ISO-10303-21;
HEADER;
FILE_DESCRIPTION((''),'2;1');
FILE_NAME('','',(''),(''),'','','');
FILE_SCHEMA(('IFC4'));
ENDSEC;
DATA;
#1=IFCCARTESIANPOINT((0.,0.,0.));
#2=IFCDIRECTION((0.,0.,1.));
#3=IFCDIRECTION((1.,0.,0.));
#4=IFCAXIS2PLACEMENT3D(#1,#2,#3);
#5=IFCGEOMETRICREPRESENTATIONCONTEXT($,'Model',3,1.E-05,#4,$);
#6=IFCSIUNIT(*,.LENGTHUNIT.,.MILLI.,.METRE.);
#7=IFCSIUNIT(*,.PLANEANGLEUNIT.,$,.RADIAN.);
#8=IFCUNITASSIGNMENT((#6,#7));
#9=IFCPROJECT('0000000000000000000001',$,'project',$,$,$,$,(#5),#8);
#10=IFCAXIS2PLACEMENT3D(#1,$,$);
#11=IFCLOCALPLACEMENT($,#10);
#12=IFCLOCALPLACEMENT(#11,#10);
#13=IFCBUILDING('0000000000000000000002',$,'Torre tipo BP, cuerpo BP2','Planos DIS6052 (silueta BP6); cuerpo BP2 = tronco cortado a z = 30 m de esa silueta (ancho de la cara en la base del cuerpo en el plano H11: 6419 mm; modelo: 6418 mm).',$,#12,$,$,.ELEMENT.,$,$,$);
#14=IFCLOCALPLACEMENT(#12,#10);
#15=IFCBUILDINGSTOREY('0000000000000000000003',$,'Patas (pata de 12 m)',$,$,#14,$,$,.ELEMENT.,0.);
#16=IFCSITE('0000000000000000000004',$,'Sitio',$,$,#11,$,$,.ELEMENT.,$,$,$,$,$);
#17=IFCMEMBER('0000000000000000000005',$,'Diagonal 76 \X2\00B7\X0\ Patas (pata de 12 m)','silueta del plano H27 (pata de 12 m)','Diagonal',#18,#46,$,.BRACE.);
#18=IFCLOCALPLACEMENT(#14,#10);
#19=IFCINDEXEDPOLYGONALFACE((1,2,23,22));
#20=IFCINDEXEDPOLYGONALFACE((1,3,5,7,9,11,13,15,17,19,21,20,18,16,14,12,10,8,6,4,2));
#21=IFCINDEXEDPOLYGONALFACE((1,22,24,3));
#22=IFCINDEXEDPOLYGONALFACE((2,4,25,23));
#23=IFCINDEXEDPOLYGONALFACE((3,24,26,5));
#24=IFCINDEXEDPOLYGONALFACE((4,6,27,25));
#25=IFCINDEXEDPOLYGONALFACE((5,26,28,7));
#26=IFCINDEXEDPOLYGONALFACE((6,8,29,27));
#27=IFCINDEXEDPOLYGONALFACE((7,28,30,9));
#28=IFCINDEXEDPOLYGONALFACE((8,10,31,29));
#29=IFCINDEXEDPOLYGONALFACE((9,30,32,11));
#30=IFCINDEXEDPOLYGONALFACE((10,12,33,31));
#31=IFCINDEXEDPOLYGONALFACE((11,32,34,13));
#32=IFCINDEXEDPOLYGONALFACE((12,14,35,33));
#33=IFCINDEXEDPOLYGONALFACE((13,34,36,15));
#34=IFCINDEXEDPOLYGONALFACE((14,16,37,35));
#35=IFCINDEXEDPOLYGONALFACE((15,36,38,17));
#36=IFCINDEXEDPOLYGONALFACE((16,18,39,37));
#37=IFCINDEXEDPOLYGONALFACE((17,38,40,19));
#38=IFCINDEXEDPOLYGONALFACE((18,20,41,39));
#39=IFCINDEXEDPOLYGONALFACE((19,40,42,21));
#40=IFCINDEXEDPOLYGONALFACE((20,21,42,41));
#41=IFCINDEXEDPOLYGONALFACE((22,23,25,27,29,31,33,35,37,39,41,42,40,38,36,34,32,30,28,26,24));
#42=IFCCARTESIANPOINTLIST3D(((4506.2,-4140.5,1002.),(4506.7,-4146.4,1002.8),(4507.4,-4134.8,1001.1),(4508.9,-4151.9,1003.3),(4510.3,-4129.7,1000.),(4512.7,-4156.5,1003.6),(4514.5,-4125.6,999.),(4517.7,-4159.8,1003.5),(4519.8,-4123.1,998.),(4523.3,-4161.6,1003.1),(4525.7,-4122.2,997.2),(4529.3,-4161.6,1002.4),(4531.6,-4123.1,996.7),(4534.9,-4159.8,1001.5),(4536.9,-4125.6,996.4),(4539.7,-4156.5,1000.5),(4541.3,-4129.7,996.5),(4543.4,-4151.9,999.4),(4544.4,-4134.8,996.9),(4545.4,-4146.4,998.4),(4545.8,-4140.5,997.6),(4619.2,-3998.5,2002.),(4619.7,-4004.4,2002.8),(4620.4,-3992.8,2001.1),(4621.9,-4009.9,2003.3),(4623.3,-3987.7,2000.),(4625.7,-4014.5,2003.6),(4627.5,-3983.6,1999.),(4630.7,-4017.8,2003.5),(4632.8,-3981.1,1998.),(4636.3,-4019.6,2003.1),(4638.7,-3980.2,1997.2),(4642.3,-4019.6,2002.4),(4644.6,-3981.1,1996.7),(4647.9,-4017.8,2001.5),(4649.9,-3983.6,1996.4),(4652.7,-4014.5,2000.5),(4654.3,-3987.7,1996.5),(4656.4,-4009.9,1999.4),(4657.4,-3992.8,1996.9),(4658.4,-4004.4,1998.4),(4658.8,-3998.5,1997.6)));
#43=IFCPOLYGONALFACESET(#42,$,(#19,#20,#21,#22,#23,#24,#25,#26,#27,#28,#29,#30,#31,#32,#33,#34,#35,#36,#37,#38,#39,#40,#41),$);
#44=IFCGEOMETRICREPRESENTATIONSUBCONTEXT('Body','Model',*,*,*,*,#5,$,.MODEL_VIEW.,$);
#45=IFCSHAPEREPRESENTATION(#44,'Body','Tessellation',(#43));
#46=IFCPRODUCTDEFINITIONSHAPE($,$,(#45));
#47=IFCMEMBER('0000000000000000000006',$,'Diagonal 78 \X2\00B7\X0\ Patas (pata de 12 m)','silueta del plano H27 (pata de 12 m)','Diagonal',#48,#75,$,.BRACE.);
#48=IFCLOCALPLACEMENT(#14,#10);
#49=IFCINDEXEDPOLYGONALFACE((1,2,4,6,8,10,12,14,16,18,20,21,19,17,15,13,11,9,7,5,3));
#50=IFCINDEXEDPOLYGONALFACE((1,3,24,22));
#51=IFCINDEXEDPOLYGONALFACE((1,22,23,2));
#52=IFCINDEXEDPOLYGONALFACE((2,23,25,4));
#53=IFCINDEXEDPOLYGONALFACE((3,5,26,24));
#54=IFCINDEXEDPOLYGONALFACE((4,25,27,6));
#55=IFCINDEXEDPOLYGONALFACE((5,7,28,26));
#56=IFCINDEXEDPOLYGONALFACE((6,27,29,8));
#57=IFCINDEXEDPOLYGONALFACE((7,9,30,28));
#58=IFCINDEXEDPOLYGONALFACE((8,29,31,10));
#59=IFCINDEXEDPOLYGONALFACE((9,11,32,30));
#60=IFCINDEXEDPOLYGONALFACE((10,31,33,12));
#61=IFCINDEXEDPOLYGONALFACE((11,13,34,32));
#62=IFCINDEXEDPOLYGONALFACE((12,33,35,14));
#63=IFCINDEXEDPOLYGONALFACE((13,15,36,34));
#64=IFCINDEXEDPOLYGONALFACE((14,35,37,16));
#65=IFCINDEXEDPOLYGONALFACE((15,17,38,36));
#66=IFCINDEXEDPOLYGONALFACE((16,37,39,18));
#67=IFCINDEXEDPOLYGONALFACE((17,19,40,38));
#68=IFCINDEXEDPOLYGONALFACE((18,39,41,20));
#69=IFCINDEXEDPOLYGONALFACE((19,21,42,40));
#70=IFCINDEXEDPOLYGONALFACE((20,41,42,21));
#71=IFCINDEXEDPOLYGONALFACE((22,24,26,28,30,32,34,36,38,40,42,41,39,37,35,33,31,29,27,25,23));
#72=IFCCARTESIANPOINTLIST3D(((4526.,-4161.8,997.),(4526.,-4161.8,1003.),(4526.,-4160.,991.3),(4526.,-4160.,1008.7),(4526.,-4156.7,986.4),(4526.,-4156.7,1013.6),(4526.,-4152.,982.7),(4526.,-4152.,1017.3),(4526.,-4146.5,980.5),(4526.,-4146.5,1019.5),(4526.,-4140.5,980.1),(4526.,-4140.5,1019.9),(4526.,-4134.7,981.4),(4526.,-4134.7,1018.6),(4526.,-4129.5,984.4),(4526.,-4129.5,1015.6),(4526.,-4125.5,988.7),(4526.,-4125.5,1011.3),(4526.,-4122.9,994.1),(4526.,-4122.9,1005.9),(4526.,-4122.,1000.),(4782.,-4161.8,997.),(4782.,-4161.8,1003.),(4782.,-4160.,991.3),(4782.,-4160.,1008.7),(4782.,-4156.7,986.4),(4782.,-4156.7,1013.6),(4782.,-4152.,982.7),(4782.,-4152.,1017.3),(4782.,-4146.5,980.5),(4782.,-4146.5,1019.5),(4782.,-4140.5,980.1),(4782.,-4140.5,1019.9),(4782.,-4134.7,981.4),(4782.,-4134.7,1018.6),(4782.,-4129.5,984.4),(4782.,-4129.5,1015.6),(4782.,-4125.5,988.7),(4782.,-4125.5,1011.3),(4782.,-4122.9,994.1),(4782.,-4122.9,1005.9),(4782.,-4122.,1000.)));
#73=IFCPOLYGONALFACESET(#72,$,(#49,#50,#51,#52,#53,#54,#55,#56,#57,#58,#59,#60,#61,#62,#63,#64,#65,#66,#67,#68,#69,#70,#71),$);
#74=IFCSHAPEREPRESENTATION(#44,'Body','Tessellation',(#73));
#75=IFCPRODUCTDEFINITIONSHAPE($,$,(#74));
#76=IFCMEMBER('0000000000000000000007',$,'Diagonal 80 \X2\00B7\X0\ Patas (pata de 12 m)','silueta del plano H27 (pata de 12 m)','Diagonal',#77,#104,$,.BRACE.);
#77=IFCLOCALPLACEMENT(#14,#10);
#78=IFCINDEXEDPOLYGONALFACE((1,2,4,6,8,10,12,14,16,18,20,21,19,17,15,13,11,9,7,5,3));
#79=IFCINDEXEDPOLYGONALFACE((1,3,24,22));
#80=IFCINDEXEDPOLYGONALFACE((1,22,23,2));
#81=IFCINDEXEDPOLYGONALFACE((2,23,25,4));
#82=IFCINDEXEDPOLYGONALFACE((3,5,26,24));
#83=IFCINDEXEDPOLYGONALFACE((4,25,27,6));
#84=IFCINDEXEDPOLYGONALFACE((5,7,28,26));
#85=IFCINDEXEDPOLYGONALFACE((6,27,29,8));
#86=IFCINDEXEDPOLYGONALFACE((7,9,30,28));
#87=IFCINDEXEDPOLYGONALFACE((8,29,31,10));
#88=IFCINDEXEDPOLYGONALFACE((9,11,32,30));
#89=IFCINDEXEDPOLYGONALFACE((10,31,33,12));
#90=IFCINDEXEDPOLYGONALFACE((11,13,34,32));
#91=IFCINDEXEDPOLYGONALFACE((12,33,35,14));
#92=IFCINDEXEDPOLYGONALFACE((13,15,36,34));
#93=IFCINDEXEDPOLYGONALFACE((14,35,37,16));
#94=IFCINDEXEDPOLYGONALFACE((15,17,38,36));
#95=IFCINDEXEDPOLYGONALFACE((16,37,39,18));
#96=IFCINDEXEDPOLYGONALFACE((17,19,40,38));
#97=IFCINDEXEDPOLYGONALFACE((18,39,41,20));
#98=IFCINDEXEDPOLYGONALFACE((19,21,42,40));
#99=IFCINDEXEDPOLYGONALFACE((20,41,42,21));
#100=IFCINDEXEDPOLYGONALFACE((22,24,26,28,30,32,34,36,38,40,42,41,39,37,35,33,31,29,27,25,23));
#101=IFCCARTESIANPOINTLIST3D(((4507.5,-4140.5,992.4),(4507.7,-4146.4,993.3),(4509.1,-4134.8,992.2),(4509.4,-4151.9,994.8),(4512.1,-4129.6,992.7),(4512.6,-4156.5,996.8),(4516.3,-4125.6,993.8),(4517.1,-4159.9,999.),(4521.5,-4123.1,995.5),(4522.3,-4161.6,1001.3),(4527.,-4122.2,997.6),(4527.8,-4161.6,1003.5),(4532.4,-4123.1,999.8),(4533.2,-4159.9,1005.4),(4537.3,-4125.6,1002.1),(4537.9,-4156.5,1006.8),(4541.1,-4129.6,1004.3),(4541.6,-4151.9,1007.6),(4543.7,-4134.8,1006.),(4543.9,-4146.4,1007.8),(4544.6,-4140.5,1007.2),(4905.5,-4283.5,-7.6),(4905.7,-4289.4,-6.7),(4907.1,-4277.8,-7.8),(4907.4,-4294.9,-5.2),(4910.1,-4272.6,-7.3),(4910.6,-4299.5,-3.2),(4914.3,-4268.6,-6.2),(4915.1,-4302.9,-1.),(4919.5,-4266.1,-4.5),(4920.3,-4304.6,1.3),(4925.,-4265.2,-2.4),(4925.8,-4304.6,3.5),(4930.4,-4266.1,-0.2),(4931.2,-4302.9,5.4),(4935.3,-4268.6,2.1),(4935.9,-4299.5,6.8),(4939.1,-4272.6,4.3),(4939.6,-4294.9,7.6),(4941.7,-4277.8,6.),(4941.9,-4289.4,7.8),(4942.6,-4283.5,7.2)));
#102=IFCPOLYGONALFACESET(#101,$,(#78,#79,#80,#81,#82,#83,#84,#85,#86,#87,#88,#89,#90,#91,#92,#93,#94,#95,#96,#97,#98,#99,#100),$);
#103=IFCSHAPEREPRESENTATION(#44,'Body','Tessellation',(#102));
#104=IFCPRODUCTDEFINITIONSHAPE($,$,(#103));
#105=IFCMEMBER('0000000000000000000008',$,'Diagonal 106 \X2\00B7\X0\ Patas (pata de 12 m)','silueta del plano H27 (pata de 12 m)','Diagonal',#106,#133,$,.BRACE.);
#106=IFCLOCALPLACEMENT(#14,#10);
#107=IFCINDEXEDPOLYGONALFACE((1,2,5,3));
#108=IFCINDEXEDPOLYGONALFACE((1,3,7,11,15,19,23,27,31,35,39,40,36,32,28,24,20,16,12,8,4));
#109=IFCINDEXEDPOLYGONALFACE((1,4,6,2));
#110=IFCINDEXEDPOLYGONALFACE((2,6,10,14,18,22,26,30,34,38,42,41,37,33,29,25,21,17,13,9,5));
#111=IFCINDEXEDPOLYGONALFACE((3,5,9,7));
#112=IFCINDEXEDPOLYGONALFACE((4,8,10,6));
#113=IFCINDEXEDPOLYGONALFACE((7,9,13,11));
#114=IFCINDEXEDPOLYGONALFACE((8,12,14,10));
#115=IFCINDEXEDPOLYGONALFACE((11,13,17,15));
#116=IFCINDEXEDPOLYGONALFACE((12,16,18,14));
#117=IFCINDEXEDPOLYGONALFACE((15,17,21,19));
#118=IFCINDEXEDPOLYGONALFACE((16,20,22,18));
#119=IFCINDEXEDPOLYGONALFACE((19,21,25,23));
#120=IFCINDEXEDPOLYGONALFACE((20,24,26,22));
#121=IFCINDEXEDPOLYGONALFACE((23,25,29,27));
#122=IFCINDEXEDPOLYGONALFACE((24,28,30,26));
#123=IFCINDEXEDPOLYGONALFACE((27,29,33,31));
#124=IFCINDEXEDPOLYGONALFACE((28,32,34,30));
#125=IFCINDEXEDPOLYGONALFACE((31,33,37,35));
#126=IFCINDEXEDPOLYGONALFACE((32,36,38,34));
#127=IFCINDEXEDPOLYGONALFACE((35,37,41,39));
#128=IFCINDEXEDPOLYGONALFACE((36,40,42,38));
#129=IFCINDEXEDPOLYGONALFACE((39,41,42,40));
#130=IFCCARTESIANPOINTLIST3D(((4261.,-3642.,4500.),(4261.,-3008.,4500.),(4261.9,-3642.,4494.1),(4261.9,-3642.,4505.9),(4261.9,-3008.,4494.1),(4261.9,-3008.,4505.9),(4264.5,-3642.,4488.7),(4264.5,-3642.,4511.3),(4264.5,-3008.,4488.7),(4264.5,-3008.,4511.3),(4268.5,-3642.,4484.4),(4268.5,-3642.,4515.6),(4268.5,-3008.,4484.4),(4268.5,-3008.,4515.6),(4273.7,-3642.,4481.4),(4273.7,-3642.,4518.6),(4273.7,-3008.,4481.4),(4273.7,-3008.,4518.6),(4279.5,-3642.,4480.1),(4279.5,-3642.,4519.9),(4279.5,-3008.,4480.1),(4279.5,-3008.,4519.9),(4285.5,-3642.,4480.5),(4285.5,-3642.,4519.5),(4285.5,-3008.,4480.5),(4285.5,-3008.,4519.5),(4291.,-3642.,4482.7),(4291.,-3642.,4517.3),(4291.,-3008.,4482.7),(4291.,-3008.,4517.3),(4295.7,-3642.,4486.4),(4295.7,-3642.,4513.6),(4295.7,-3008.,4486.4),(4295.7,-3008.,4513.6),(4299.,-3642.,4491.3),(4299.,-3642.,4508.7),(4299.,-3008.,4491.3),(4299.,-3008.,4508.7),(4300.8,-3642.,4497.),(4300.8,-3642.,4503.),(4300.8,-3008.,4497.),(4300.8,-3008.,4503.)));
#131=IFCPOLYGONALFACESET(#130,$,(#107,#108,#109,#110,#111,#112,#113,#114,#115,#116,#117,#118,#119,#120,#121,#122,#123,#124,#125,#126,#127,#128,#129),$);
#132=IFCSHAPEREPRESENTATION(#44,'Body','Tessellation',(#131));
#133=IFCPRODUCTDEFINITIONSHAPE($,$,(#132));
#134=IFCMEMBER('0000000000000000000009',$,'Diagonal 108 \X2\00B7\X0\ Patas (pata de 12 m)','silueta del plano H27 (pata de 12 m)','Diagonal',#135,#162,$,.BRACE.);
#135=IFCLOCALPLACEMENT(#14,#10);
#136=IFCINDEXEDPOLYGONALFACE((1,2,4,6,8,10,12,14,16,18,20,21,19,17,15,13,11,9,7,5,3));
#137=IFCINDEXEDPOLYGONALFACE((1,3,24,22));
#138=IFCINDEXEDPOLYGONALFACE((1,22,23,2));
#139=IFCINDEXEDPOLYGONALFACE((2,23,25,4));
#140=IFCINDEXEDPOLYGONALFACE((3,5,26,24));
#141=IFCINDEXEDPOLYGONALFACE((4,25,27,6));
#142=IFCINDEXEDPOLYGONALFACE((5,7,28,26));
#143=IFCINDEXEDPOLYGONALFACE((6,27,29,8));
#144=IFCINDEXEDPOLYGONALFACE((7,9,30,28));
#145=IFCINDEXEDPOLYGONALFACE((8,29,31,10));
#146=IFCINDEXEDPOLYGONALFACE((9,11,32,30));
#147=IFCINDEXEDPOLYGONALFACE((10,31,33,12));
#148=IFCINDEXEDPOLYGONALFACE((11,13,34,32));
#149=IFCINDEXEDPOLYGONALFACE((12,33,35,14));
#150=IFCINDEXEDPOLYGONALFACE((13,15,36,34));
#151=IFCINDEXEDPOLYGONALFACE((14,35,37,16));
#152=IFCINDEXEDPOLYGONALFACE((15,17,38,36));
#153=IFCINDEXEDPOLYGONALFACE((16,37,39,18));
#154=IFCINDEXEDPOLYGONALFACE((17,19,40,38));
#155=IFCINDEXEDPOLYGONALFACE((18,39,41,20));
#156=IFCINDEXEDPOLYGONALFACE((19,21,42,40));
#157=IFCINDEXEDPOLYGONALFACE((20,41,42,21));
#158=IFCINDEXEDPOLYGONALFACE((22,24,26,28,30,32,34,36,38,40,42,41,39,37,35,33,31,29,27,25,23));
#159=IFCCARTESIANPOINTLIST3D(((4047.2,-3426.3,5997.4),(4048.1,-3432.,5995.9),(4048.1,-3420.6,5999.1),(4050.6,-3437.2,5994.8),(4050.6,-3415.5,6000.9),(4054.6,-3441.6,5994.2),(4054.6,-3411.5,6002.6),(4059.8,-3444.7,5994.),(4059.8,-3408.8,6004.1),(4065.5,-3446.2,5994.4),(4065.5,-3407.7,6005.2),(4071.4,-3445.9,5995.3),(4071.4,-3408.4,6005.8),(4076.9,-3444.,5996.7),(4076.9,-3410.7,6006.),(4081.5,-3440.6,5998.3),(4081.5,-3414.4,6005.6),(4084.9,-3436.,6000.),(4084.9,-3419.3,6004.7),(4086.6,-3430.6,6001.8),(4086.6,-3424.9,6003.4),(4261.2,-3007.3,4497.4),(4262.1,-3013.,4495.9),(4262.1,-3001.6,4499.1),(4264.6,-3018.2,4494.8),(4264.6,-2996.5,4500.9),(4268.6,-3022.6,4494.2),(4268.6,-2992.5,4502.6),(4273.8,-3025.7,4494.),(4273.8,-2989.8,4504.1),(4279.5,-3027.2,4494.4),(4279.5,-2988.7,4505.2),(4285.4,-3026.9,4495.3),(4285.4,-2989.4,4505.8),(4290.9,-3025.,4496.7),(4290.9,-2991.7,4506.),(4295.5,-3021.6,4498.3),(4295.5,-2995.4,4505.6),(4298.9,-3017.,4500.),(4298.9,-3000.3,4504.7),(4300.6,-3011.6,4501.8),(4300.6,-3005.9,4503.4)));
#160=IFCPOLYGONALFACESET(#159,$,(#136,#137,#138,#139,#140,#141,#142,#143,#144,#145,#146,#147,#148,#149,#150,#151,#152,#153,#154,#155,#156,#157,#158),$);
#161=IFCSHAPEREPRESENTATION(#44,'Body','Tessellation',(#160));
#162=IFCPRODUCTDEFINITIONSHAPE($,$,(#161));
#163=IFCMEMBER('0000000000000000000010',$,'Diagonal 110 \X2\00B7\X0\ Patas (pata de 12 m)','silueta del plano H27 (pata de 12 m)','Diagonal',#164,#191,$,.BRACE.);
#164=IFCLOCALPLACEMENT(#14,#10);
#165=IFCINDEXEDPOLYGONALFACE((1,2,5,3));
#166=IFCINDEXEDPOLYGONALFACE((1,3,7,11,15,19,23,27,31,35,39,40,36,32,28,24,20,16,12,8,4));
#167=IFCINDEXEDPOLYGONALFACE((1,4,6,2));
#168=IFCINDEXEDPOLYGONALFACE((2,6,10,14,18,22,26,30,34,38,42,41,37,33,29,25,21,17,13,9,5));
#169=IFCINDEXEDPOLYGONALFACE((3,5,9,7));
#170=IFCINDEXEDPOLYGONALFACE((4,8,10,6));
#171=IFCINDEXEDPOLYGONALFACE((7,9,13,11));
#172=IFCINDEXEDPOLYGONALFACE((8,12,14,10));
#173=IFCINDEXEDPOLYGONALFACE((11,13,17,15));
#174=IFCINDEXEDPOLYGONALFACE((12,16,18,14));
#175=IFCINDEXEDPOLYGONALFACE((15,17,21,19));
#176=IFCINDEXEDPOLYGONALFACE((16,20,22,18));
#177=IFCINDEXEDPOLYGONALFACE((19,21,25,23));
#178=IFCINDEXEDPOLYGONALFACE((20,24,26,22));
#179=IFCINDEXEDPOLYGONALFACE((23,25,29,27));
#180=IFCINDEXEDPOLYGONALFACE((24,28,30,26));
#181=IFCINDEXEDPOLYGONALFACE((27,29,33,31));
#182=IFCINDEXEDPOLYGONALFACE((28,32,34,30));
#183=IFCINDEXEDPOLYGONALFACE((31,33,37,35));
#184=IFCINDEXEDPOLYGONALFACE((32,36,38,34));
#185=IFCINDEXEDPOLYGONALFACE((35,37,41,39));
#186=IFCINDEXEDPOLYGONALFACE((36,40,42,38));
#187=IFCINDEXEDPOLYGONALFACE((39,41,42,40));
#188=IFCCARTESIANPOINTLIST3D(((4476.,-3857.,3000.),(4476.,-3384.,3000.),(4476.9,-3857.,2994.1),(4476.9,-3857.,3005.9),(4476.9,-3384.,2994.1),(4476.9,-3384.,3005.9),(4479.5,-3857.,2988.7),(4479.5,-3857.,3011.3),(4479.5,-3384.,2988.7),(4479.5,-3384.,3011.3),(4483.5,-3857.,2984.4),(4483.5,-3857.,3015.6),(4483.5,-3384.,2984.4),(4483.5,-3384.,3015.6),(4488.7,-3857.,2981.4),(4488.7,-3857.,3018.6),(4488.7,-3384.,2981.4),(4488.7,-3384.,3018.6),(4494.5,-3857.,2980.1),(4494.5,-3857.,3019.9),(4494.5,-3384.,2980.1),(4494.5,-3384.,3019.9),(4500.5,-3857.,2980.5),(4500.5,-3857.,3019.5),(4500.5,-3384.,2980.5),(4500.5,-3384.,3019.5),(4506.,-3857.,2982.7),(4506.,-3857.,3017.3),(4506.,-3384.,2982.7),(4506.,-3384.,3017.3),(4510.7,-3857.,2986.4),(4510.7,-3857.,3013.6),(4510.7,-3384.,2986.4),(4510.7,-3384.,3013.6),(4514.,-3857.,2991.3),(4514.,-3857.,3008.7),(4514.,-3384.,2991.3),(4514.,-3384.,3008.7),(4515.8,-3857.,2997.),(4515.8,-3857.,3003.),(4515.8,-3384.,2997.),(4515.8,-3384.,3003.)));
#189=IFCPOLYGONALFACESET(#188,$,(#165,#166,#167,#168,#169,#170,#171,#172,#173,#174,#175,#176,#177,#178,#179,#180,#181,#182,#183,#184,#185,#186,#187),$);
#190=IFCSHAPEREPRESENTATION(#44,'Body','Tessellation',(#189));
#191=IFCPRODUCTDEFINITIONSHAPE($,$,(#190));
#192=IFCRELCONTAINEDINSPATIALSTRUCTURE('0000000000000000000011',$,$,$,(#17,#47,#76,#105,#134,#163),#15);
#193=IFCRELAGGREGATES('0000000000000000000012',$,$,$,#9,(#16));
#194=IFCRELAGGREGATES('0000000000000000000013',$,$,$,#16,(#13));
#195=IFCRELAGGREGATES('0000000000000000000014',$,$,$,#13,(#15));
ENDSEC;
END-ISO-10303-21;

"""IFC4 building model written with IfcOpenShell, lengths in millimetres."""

from ifc_helpers import new_model, si_unit, frame, origin, origin_with_axes, place, context, subcontext, project, spatial, circle, extrude, element, save


model = new_model("IFC4")

# Units and contexts
model_context = context("Model", 3, precision=1e-05, world=origin_with_axes())
body_context = subcontext(model_context, "Body", "Model", "MODEL_VIEW")
ifc_project = project(units=[si_unit("LENGTHUNIT", "METRE", prefix="MILLI"), si_unit("PLANEANGLEUNIT", "RADIAN")], contexts=[model_context])

# Site, building, storey
site_placement = place(None, origin())
site = spatial("IfcSite", under=ifc_project, at=site_placement, Name="Sitio", CompositionType="ELEMENT")
building_placement = place(site_placement, origin())
building = spatial("IfcBuilding", under=site, at=building_placement, Name="Torre tipo BP, cuerpo BP2", Description="Planos DIS6052 (silueta BP6); cuerpo BP2 = tronco cortado a z = 30 m de esa silueta (ancho de la cara en la base del cuerpo en el plano H11: 6419 mm; modelo: 6418 mm).", CompositionType="ELEMENT")
storey_placement = place(building_placement, origin())
storey = spatial("IfcBuildingStorey", under=building, at=storey_placement, Name="Patas (pata de 12 m)", CompositionType="ELEMENT", Elevation=0.0)

# Members
member_1_placement = place(storey_placement, frame((4526.0, -4142.0, 1000.0), z_axis=(0.111184, 0.139718, 0.983929), x_axis=(-0.015688, 0.990191, -0.138834)))
element("IfcMember", 1, at=member_1_placement, inside=storey, Name="Diagonal 76 · Patas (pata de 12 m)", Description="silueta del plano H27 (pata de 12 m)", ObjectType="Diagonal", PredefinedType="BRACE", context=body_context, shape_type="SweptSolid", body=[
    extrude(circle(Radius=20.0), None, (0.0, 0.0, 1.0), 1016.3),
])
member_2_placement = place(storey_placement, frame((4782.0, -4142.0, 1000.0), z_axis=(-1.0, 0.0, 0.0), x_axis=(0.0, 1.0, 0.0)))
element("IfcMember", 2, at=member_2_placement, inside=storey, Name="Diagonal 78 · Patas (pata de 12 m)", Description="silueta del plano H27 (pata de 12 m)", ObjectType="Diagonal", PredefinedType="BRACE", context=body_context, shape_type="SweptSolid", body=[
    extrude(circle(Radius=20.0), None, (0.0, 0.0, 1.0), 256.0),
])
member_3_placement = place(storey_placement, frame((4924.0, -4285.0, 0.0), z_axis=(-0.366567, 0.131706, 0.921022), x_axis=(0.048703, 0.991289, -0.12237)))
element("IfcMember", 3, at=member_3_placement, inside=storey, Name="Diagonal 80 · Patas (pata de 12 m)", Description="silueta del plano H27 (pata de 12 m)", ObjectType="Diagonal", PredefinedType="BRACE", context=body_context, shape_type="SweptSolid", body=[
    extrude(circle(Radius=20.0), None, (0.0, 0.0, 1.0), 1085.7),
])
member_4_placement = place(storey_placement, frame((4281.0, -3642.0, 4500.0), z_axis=(0.0, 1.0, 0.0), x_axis=(-1.0, 0.0, 0.0)))
element("IfcMember", 4, at=member_4_placement, inside=storey, Name="Diagonal 106 · Patas (pata de 12 m)", Description="silueta del plano H27 (pata de 12 m)", ObjectType="Diagonal", PredefinedType="BRACE", context=body_context, shape_type="SweptSolid", body=[
    extrude(circle(Radius=20.0), None, (0.0, 0.0, 1.0), 634.0),
])
member_5_placement = place(storey_placement, frame((4281.0, -3008.0, 4500.0), z_axis=(-0.136128, -0.26653, 0.954165), x_axis=(-0.990691, 0.036623, -0.131109)))
element("IfcMember", 5, at=member_5_placement, inside=storey, Name="Diagonal 108 · Patas (pata de 12 m)", Description="silueta del plano H27 (pata de 12 m)", ObjectType="Diagonal", PredefinedType="BRACE", context=body_context, shape_type="SweptSolid", body=[
    extrude(circle(Radius=20.0), None, (0.0, 0.0, 1.0), 1572.1),
])
member_6_placement = place(storey_placement, frame((4496.0, -3857.0, 3000.0), z_axis=(0.0, 1.0, 0.0), x_axis=(-1.0, 0.0, 0.0)))
element("IfcMember", 6, at=member_6_placement, inside=storey, Name="Diagonal 110 · Patas (pata de 12 m)", Description="silueta del plano H27 (pata de 12 m)", ObjectType="Diagonal", PredefinedType="BRACE", context=body_context, shape_type="SweptSolid", body=[
    extrude(circle(Radius=20.0), None, (0.0, 0.0, 1.0), 473.0),
])

save(model, "model.ifc")
